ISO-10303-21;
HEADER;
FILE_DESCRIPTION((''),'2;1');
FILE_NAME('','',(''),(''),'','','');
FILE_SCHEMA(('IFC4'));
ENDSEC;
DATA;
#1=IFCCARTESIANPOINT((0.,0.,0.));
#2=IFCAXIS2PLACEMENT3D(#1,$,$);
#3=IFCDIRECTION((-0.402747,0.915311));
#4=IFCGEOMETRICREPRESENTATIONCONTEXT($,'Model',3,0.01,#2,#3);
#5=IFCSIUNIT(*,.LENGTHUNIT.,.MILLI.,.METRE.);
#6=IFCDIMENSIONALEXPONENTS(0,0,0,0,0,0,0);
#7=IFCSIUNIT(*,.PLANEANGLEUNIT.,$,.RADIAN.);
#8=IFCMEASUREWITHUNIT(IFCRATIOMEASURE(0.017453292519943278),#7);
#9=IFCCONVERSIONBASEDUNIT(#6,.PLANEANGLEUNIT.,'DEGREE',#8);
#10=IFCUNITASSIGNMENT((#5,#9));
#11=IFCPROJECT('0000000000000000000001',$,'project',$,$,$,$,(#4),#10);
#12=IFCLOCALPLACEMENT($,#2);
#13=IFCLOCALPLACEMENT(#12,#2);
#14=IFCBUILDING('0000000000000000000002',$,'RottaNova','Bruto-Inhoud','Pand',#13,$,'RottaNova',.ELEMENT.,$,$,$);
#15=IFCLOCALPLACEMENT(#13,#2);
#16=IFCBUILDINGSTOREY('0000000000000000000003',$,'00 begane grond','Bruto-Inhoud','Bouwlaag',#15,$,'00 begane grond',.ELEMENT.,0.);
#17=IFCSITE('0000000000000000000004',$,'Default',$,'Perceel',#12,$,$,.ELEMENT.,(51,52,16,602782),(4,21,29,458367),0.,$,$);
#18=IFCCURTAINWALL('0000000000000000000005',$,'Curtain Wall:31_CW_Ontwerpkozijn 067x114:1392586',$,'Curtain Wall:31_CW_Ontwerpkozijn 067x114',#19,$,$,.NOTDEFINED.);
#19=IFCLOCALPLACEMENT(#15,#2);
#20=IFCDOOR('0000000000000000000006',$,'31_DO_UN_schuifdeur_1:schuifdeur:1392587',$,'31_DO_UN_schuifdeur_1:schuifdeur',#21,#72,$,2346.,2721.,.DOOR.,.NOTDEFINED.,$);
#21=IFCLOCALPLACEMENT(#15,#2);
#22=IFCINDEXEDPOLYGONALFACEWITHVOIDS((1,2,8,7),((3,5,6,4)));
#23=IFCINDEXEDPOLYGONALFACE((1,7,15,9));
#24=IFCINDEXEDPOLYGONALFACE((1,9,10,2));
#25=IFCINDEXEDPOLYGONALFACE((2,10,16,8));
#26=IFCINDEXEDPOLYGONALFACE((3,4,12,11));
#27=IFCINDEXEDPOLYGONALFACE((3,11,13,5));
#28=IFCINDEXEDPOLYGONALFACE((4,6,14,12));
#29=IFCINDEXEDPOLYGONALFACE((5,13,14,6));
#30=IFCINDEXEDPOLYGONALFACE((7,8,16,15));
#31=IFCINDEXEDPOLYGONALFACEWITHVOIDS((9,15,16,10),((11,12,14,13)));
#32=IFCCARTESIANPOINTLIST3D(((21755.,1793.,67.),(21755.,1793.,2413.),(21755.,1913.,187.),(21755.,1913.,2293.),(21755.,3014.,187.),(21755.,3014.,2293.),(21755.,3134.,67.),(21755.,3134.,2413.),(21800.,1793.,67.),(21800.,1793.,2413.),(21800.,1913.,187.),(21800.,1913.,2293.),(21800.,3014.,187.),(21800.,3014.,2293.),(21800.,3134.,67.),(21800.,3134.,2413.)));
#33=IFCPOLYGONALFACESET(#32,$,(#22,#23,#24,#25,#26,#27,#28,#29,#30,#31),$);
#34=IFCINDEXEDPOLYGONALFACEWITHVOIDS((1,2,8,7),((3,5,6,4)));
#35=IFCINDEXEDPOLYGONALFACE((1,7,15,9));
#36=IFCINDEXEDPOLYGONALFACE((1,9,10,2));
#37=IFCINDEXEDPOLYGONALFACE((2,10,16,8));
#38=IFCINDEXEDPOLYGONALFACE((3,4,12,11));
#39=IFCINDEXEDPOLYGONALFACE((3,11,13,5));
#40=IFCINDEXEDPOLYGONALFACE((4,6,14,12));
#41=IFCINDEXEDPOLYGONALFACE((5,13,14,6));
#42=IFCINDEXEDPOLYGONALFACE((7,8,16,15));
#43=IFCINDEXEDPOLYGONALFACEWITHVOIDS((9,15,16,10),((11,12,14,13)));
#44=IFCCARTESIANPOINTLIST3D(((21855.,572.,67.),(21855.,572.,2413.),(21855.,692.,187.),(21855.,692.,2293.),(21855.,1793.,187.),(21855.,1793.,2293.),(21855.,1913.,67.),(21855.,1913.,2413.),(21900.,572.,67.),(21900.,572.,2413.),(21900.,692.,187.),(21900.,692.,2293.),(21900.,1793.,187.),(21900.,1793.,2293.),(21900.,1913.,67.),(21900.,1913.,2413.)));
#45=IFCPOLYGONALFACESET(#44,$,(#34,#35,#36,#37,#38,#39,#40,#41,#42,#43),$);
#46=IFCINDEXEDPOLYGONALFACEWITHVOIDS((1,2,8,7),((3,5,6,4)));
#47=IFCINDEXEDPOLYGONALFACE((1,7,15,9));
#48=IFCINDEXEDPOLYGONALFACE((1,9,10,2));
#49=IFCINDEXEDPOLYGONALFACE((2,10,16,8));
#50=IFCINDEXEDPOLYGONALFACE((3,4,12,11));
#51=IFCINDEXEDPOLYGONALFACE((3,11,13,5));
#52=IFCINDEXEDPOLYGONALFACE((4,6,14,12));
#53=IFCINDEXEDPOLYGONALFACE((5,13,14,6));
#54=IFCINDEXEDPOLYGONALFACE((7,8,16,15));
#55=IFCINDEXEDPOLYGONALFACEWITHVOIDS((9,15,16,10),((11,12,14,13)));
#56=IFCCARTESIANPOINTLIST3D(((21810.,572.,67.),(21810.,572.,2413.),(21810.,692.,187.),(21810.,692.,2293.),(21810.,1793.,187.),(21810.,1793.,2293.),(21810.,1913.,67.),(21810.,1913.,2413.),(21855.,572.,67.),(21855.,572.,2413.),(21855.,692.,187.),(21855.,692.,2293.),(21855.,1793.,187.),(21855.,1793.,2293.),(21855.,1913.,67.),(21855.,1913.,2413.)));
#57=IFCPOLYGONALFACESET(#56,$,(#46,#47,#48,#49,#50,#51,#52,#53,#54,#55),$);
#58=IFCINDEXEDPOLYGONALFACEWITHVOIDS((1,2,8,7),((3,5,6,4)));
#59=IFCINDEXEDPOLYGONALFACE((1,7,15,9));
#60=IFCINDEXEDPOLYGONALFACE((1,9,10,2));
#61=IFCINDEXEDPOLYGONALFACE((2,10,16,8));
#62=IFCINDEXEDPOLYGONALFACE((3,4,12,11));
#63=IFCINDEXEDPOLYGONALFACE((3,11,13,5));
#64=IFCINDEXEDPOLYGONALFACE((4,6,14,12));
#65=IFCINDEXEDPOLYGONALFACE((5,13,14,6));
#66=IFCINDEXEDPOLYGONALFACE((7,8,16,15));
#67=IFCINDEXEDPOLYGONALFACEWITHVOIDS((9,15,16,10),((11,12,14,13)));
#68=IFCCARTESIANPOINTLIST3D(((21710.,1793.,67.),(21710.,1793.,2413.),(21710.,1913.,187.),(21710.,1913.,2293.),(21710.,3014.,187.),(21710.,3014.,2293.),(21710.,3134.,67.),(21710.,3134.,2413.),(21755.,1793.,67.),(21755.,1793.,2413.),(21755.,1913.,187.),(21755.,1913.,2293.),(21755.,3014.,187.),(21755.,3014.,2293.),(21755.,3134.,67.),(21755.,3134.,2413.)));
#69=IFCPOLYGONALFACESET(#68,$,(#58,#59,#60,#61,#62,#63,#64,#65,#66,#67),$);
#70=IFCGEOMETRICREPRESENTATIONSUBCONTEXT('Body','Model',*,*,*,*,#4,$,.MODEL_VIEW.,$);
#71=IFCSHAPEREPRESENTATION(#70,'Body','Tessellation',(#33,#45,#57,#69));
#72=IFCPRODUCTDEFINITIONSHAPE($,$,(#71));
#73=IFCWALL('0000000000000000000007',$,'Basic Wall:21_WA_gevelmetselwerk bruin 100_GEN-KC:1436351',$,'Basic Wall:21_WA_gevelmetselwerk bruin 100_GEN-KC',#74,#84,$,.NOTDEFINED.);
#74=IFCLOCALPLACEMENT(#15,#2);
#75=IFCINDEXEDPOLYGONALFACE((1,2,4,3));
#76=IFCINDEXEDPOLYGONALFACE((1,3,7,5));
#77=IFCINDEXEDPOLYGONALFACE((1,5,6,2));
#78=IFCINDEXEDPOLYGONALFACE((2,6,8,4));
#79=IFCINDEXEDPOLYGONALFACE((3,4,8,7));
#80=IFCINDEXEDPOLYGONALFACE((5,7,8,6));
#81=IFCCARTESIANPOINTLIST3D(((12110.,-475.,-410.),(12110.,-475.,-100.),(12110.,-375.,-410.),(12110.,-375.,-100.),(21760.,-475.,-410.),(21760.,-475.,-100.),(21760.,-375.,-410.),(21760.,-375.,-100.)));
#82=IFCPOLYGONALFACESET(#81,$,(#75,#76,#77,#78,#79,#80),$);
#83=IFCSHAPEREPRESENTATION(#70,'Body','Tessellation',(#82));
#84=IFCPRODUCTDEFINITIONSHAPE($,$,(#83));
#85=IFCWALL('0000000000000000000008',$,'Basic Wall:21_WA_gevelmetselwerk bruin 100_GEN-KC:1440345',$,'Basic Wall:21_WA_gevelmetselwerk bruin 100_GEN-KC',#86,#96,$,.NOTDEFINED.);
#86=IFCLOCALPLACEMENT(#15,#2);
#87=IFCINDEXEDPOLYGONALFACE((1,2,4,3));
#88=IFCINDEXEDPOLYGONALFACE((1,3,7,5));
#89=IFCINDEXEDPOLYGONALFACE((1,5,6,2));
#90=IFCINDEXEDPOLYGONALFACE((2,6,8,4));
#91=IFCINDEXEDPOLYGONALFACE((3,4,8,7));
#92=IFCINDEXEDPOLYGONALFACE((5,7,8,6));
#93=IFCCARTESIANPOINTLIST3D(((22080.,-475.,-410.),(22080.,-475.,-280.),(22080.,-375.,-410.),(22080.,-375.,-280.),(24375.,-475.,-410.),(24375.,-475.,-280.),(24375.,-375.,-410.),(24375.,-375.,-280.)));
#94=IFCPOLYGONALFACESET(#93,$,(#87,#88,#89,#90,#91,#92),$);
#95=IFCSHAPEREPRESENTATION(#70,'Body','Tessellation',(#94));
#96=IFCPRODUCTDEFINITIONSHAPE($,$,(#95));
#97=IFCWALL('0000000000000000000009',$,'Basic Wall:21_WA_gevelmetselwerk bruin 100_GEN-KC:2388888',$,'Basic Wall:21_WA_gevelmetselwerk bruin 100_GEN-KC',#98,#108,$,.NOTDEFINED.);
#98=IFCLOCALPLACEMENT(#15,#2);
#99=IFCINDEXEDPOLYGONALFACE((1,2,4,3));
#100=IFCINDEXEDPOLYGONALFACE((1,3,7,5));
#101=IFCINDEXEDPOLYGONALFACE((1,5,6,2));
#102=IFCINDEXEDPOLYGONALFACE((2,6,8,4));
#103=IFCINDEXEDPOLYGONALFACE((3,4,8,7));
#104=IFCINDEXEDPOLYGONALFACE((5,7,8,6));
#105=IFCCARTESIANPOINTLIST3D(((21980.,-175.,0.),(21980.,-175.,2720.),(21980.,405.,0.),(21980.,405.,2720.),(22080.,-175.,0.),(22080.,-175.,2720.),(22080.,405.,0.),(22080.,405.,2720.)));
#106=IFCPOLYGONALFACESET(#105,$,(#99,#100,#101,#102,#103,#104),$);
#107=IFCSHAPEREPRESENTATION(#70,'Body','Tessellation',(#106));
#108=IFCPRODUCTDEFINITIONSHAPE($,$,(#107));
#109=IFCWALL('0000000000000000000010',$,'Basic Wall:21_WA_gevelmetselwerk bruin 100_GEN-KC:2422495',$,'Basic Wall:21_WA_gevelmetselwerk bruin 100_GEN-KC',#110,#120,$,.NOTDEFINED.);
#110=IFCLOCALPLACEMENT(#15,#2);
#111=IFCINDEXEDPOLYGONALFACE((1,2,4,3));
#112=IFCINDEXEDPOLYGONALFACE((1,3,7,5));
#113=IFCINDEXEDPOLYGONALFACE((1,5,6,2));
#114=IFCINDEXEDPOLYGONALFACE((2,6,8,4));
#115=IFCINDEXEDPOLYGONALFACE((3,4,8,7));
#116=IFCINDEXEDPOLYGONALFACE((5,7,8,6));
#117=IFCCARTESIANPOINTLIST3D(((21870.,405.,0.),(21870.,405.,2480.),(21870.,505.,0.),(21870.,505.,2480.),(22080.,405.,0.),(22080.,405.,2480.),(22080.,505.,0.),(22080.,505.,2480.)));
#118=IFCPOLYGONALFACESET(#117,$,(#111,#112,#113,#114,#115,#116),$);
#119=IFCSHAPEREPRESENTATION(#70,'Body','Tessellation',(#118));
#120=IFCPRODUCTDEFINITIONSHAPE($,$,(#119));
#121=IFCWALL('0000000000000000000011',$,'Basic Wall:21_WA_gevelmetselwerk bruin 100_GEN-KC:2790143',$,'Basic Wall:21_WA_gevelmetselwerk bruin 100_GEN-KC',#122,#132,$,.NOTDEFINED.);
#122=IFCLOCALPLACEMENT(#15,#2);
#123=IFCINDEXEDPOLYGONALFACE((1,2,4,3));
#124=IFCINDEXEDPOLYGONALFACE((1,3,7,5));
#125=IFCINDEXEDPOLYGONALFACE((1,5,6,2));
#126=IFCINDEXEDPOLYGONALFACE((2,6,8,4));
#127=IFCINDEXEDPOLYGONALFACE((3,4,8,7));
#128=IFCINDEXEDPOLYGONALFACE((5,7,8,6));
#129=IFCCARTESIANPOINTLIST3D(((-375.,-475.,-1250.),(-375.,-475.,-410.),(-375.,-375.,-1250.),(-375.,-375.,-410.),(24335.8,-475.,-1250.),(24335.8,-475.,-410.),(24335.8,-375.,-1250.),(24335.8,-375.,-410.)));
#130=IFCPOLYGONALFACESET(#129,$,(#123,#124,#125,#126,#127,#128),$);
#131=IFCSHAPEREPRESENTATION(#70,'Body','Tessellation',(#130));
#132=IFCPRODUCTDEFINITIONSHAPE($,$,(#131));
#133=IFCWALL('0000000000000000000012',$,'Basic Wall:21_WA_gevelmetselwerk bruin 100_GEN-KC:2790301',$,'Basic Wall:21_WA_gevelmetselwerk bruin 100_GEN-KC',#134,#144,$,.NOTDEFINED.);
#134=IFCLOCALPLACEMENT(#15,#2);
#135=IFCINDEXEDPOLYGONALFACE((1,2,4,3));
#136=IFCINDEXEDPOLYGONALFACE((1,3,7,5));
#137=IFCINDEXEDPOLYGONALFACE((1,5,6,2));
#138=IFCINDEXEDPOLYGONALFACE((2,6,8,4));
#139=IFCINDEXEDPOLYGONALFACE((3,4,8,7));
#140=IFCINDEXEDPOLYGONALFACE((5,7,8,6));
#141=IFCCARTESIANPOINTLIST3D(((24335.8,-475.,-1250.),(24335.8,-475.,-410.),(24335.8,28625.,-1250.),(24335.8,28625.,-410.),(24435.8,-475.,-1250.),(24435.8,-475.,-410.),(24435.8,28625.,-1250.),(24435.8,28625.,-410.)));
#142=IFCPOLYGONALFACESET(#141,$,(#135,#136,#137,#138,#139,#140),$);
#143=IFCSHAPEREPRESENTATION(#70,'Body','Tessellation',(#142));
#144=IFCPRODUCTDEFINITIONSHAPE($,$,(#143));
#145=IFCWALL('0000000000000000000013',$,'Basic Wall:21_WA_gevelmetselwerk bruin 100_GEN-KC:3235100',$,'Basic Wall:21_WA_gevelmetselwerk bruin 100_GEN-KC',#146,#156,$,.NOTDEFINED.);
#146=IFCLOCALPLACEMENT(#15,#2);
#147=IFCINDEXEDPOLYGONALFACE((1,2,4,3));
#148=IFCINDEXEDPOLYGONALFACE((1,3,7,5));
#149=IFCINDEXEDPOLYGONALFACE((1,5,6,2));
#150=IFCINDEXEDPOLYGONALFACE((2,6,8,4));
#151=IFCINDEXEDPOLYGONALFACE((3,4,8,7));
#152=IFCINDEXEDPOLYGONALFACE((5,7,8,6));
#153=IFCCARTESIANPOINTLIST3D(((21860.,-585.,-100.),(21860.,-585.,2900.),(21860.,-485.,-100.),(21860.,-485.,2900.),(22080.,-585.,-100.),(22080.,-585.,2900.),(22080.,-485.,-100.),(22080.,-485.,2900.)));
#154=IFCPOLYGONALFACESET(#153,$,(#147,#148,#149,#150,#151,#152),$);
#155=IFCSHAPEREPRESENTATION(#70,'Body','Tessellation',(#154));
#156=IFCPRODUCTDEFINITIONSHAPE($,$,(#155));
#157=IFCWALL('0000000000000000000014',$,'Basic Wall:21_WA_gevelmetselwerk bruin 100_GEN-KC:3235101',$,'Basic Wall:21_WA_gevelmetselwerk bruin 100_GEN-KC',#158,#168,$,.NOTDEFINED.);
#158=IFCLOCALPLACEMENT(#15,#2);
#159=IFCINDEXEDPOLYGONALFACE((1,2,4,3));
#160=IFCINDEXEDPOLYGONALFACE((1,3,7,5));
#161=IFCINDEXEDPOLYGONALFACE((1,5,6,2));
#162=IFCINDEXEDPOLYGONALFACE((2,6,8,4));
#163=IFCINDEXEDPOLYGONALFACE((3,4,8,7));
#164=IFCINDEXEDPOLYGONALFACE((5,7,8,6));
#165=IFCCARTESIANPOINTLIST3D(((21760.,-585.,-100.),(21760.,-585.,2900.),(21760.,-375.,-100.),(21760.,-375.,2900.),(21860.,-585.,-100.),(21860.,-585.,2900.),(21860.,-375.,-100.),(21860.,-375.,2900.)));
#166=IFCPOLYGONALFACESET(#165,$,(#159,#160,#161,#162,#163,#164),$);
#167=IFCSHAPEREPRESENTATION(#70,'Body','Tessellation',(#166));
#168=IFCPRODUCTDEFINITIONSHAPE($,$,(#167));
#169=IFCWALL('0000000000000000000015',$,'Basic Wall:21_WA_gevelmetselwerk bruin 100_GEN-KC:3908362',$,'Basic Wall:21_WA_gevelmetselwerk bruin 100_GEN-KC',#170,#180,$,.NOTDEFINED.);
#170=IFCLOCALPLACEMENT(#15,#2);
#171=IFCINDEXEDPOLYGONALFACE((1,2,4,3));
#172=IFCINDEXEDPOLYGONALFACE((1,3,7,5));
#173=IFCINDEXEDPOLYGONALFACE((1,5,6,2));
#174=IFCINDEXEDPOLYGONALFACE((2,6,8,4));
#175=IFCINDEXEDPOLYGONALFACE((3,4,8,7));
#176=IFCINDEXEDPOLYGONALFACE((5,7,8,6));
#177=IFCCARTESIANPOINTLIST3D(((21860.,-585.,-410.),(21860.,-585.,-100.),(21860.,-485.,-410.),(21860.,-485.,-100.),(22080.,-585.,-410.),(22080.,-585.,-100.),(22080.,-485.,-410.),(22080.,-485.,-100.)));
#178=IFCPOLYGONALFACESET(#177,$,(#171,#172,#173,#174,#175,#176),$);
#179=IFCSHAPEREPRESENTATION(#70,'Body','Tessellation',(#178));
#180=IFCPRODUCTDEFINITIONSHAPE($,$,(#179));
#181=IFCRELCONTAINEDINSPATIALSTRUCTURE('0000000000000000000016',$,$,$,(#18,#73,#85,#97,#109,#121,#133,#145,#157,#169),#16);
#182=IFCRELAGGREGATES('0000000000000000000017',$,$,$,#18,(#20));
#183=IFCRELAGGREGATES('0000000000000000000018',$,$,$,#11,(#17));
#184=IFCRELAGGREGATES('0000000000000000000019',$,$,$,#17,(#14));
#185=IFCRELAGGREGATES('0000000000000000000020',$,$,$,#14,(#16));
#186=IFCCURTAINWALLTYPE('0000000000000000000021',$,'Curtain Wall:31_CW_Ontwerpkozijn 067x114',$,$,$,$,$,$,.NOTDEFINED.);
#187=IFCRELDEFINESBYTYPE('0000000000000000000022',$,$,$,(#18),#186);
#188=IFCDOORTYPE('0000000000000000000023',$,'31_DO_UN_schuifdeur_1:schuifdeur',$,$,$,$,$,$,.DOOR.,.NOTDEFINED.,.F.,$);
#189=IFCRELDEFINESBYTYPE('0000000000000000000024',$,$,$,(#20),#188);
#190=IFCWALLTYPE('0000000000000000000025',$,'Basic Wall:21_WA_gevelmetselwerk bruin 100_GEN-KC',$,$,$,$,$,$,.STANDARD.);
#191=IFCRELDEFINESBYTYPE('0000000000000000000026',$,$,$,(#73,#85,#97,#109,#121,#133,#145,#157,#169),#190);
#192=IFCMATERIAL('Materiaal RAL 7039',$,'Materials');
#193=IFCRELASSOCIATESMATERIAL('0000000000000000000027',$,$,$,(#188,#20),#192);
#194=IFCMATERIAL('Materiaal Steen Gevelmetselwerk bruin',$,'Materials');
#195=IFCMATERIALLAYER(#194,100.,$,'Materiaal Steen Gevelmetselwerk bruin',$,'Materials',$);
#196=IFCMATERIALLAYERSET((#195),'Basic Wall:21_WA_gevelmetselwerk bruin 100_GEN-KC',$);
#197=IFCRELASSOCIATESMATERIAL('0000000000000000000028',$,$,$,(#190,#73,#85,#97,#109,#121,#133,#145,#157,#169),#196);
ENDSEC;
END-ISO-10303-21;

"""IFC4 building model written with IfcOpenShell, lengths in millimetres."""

from ifc_helpers import new_model, entity, si_unit, converted_unit, direction, frame, frame_2d, origin, place, context, subcontext, project, spatial, polyline, rectangle, outline, extrude, source, transform, mapped, material, layer, layer_set, type_object, type_shapes, element, aggregate, save


model = new_model("IFC4")

# Units and contexts
model_context = context("Model", 3, precision=0.01, world=origin(), true_north=direction((-0.402747, 0.915311)))
body_context = subcontext(model_context, "Body", "Model", "MODEL_VIEW")
ifc_project = project(units=[si_unit("LENGTHUNIT", "METRE", prefix="MILLI"), converted_unit("PLANEANGLEUNIT", "DEGREE", entity("IfcRatioMeasure", 0.017453292519943278), si_unit("PLANEANGLEUNIT", "RADIAN"), dimensions=[0, 0, 0, 0, 0, 0, 0])], contexts=[model_context])

# Site, building, storey
site_placement = place(None, origin())
site = spatial("IfcSite", under=ifc_project, at=site_placement, Name="Default", ObjectType="Perceel", CompositionType="ELEMENT", RefLatitude=(51, 52, 16, 602782), RefLongitude=(4, 21, 29, 458367), RefElevation=0.0)
building_placement = place(site_placement, origin())
building = spatial("IfcBuilding", under=site, at=building_placement, Name="RottaNova", Description="Bruto-Inhoud", ObjectType="Pand", LongName="RottaNova", CompositionType="ELEMENT")
storey_placement = place(building_placement, origin())
storey = spatial("IfcBuildingStorey", under=building, at=storey_placement, Name="00 begane grond", Description="Bruto-Inhoud", ObjectType="Bouwlaag", LongName="00 begane grond", CompositionType="ELEMENT", Elevation=0.0)

# Curtain wall
curtain_wall_type = type_object("IfcCurtainWallType", Name="Curtain Wall:31_CW_Ontwerpkozijn 067x114", PredefinedType="NOTDEFINED")
curtain_wall_placement = place(storey_placement, origin())
curtain_wall = element("IfcCurtainWall", 1, at=curtain_wall_placement, inside=storey, type_object=curtain_wall_type, Name="Curtain Wall:31_CW_Ontwerpkozijn 067x114:1392586", ObjectType="Curtain Wall:31_CW_Ontwerpkozijn 067x114", PredefinedType="NOTDEFINED")
ifc_material_1 = material(Name="Materiaal RAL 7039", Category="Materials")

# Door
door_type = type_object("IfcDoorType", Name="31_DO_UN_schuifdeur_1:schuifdeur", OperationType="NOTDEFINED", ParameterTakesPrecedence=False, PredefinedType="DOOR", material=ifc_material_1)
shared_shape_1 = source(origin(), body_context, "Body", "SweptSolid", [
    extrude(outline(polyline([(-670.5, -1173.0), (670.5, -1173.0), (670.5, 1173.0), (-670.5, 1173.0), (-670.5, -1173.0)]), holes=[polyline([(-550.5, -1053.0), (-550.5, 1053.0), (550.5, 1053.0), (550.5, -1053.0), (-550.5, -1053.0)])]), frame((-610.5, 90.0, 1173.0), z_axis=(0.0, -1.0, 0.0), x_axis=(-1.0, 0.0, 0.0)), (0.0, 0.0, 1.0), 45.0),
    extrude(outline(polyline([(-670.5, -1173.0), (670.5, -1173.0), (670.5, 1173.0), (-670.5, 1173.0), (-670.5, -1173.0)]), holes=[polyline([(-550.5, -1053.0), (-550.5, 1053.0), (550.5, 1053.0), (550.5, -1053.0), (-550.5, -1053.0)])]), frame((610.5, 190.0, 1173.0), z_axis=(0.0, -1.0, 0.0), x_axis=(-1.0, 0.0, 0.0)), (0.0, 0.0, 1.0), 45.0),
    extrude(outline(polyline([(-670.5, -1173.0), (670.5, -1173.0), (670.5, 1173.0), (-670.5, 1173.0), (-670.5, -1173.0)]), holes=[polyline([(-550.5, -1053.0), (-550.5, 1053.0), (550.5, 1053.0), (550.5, -1053.0), (-550.5, -1053.0)])]), frame((610.5, 145.0, 1173.0), z_axis=(0.0, -1.0, 0.0), x_axis=(-1.0, 0.0, 0.0)), (0.0, 0.0, 1.0), 45.0),
    extrude(outline(polyline([(-670.5, -1173.0), (670.5, -1173.0), (670.5, 1173.0), (-670.5, 1173.0), (-670.5, -1173.0)]), holes=[polyline([(-550.5, -1053.0), (-550.5, 1053.0), (550.5, 1053.0), (550.5, -1053.0), (-550.5, -1053.0)])]), frame((-610.5, 45.0, 1173.0), z_axis=(0.0, -1.0, 0.0), x_axis=(-1.0, 0.0, 0.0)), (0.0, 0.0, 1.0), 45.0),
])
type_shapes(door_type, [shared_shape_1])
door_placement = place(curtain_wall_placement, frame((21710.0, 1853.0, 67.0), z_axis=(0.0, 0.0, 1.0), x_axis=(0.0, -1.0, 0.0)))
door = element("IfcDoor", 2, at=door_placement, type_object=door_type, material=ifc_material_1, Name="31_DO_UN_schuifdeur_1:schuifdeur:1392587", ObjectType="31_DO_UN_schuifdeur_1:schuifdeur", OperationType="NOTDEFINED", OverallHeight=2346.0, OverallWidth=2721.0, PredefinedType="DOOR", context=body_context, shape_type="MappedRepresentation", body=[
    mapped(shared_shape_1, transform((0.0, 0.0, 0.0), scale=1.0)),
])
aggregate(curtain_wall, [door])

# Walls
ifc_material_2 = material(Name="Materiaal Steen Gevelmetselwerk bruin", Category="Materials")
ifc_layer_1 = layer(ifc_material_2, 100.0, Name="Materiaal Steen Gevelmetselwerk bruin", Category="Materials")
ifc_layer_set_1 = layer_set([ifc_layer_1], Name="Basic Wall:21_WA_gevelmetselwerk bruin 100_GEN-KC")
wall_type_1 = type_object("IfcWallType", Name="Basic Wall:21_WA_gevelmetselwerk bruin 100_GEN-KC", PredefinedType="STANDARD", material=ifc_layer_set_1)
wall_1_placement = place(storey_placement, frame((21760.0, -425.0, -410.0), z_axis=(0.0, 0.0, 1.0), x_axis=(-1.0, 0.0, 0.0)))
element("IfcWall", 3, at=wall_1_placement, inside=storey, type_object=wall_type_1, material=ifc_layer_set_1, Name="Basic Wall:21_WA_gevelmetselwerk bruin 100_GEN-KC:1436351", ObjectType="Basic Wall:21_WA_gevelmetselwerk bruin 100_GEN-KC", PredefinedType="NOTDEFINED", context=body_context, shape_type="SweptSolid", body=[
    extrude(rectangle(XDim=9650.0, YDim=100.0, at=frame_2d((4825.0, 0.0), x_axis=(-1.0, 0.0))), origin(), (0.0, 0.0, 1.0), 310.0),
])
wall_2_placement = place(storey_placement, frame((22080.0, -425.0, -410.0)))
element("IfcWall", 4, at=wall_2_placement, inside=storey, type_object=wall_type_1, material=ifc_layer_set_1, Name="Basic Wall:21_WA_gevelmetselwerk bruin 100_GEN-KC:1440345", ObjectType="Basic Wall:21_WA_gevelmetselwerk bruin 100_GEN-KC", PredefinedType="NOTDEFINED", context=body_context, shape_type="SweptSolid", body=[
    extrude(rectangle(XDim=2295.0, YDim=100.0, at=frame_2d((1147.5, 0.0), x_axis=(-1.0, 0.0))), origin(), (0.0, 0.0, 1.0), 130.0),
])
wall_3_placement = place(storey_placement, frame((22030.0, 405.0, 0.0), z_axis=(0.0, 0.0, 1.0), x_axis=(0.0, -1.0, 0.0)))
element("IfcWall", 5, at=wall_3_placement, inside=storey, type_object=wall_type_1, material=ifc_layer_set_1, Name="Basic Wall:21_WA_gevelmetselwerk bruin 100_GEN-KC:2388888", ObjectType="Basic Wall:21_WA_gevelmetselwerk bruin 100_GEN-KC", PredefinedType="NOTDEFINED", context=body_context, shape_type="SweptSolid", body=[
    extrude(rectangle(XDim=580.0, YDim=100.0, at=frame_2d((290.0, 0.0), x_axis=(-1.0, 0.0))), origin(), (0.0, 0.0, 1.0), 2720.0),
])
wall_4_placement = place(storey_placement, frame((21870.0, 455.0, 0.0)))
element("IfcWall", 6, at=wall_4_placement, inside=storey, type_object=wall_type_1, material=ifc_layer_set_1, Name="Basic Wall:21_WA_gevelmetselwerk bruin 100_GEN-KC:2422495", ObjectType="Basic Wall:21_WA_gevelmetselwerk bruin 100_GEN-KC", PredefinedType="NOTDEFINED", context=body_context, shape_type="SweptSolid", body=[
    extrude(rectangle(XDim=210.0, YDim=100.0, at=frame_2d((105.0, 0.0), x_axis=(-1.0, 0.0))), origin(), (0.0, 0.0, 1.0), 2480.0),
])
wall_5_placement = place(storey_placement, frame((24335.8, -425.0, -1250.0), z_axis=(0.0, 0.0, 1.0), x_axis=(-1.0, 0.0, 0.0)))
element("IfcWall", 7, at=wall_5_placement, inside=storey, type_object=wall_type_1, material=ifc_layer_set_1, Name="Basic Wall:21_WA_gevelmetselwerk bruin 100_GEN-KC:2790143", ObjectType="Basic Wall:21_WA_gevelmetselwerk bruin 100_GEN-KC", PredefinedType="NOTDEFINED", context=body_context, shape_type="SweptSolid", body=[
    extrude(rectangle(XDim=24710.8, YDim=100.0, at=frame_2d((12355.4, 0.0), x_axis=(-1.0, 0.0))), origin(), (0.0, 0.0, 1.0), 840.0),
])
wall_6_placement = place(storey_placement, frame((24385.8, -475.0, -1250.0), z_axis=(0.0, 0.0, 1.0), x_axis=(0.0, 1.0, 0.0)))
element("IfcWall", 8, at=wall_6_placement, inside=storey, type_object=wall_type_1, material=ifc_layer_set_1, Name="Basic Wall:21_WA_gevelmetselwerk bruin 100_GEN-KC:2790301", ObjectType="Basic Wall:21_WA_gevelmetselwerk bruin 100_GEN-KC", PredefinedType="NOTDEFINED", context=body_context, shape_type="SweptSolid", body=[
    extrude(rectangle(XDim=29100.0, YDim=100.0, at=frame_2d((14550.0, 0.0), x_axis=(-1.0, 0.0))), origin(), (0.0, 0.0, 1.0), 840.0),
])
wall_7_placement = place(storey_placement, frame((22080.0, -535.0, -100.0), z_axis=(0.0, 0.0, 1.0), x_axis=(-1.0, 0.0, 0.0)))
element("IfcWall", 9, at=wall_7_placement, inside=storey, type_object=wall_type_1, material=ifc_layer_set_1, Name="Basic Wall:21_WA_gevelmetselwerk bruin 100_GEN-KC:3235100", ObjectType="Basic Wall:21_WA_gevelmetselwerk bruin 100_GEN-KC", PredefinedType="NOTDEFINED", context=body_context, shape_type="SweptSolid", body=[
    extrude(rectangle(XDim=220.0, YDim=100.0, at=frame_2d((110.0, 0.0), x_axis=(-1.0, 0.0))), origin(), (0.0, 0.0, 1.0), 3000.0),
])
wall_8_placement = place(storey_placement, frame((21810.0, -585.0, -100.0), z_axis=(0.0, 0.0, 1.0), x_axis=(0.0, 1.0, 0.0)))
element("IfcWall", 10, at=wall_8_placement, inside=storey, type_object=wall_type_1, material=ifc_layer_set_1, Name="Basic Wall:21_WA_gevelmetselwerk bruin 100_GEN-KC:3235101", ObjectType="Basic Wall:21_WA_gevelmetselwerk bruin 100_GEN-KC", PredefinedType="NOTDEFINED", context=body_context, shape_type="SweptSolid", body=[
    extrude(rectangle(XDim=210.0, YDim=100.0, at=frame_2d((105.0, 0.0), x_axis=(-1.0, 0.0))), origin(), (0.0, 0.0, 1.0), 3000.0),
])
wall_9_placement = place(storey_placement, frame((22080.0, -535.0, -410.0), z_axis=(0.0, 0.0, 1.0), x_axis=(-1.0, 0.0, 0.0)))
element("IfcWall", 11, at=wall_9_placement, inside=storey, type_object=wall_type_1, material=ifc_layer_set_1, Name="Basic Wall:21_WA_gevelmetselwerk bruin 100_GEN-KC:3908362", ObjectType="Basic Wall:21_WA_gevelmetselwerk bruin 100_GEN-KC", PredefinedType="NOTDEFINED", context=body_context, shape_type="SweptSolid", body=[
    extrude(rectangle(XDim=220.0, YDim=100.0, at=frame_2d((110.0, 0.0), x_axis=(-1.0, 0.0))), origin(), (0.0, 0.0, 1.0), 310.0),
])

save(model, "model.ifc")
